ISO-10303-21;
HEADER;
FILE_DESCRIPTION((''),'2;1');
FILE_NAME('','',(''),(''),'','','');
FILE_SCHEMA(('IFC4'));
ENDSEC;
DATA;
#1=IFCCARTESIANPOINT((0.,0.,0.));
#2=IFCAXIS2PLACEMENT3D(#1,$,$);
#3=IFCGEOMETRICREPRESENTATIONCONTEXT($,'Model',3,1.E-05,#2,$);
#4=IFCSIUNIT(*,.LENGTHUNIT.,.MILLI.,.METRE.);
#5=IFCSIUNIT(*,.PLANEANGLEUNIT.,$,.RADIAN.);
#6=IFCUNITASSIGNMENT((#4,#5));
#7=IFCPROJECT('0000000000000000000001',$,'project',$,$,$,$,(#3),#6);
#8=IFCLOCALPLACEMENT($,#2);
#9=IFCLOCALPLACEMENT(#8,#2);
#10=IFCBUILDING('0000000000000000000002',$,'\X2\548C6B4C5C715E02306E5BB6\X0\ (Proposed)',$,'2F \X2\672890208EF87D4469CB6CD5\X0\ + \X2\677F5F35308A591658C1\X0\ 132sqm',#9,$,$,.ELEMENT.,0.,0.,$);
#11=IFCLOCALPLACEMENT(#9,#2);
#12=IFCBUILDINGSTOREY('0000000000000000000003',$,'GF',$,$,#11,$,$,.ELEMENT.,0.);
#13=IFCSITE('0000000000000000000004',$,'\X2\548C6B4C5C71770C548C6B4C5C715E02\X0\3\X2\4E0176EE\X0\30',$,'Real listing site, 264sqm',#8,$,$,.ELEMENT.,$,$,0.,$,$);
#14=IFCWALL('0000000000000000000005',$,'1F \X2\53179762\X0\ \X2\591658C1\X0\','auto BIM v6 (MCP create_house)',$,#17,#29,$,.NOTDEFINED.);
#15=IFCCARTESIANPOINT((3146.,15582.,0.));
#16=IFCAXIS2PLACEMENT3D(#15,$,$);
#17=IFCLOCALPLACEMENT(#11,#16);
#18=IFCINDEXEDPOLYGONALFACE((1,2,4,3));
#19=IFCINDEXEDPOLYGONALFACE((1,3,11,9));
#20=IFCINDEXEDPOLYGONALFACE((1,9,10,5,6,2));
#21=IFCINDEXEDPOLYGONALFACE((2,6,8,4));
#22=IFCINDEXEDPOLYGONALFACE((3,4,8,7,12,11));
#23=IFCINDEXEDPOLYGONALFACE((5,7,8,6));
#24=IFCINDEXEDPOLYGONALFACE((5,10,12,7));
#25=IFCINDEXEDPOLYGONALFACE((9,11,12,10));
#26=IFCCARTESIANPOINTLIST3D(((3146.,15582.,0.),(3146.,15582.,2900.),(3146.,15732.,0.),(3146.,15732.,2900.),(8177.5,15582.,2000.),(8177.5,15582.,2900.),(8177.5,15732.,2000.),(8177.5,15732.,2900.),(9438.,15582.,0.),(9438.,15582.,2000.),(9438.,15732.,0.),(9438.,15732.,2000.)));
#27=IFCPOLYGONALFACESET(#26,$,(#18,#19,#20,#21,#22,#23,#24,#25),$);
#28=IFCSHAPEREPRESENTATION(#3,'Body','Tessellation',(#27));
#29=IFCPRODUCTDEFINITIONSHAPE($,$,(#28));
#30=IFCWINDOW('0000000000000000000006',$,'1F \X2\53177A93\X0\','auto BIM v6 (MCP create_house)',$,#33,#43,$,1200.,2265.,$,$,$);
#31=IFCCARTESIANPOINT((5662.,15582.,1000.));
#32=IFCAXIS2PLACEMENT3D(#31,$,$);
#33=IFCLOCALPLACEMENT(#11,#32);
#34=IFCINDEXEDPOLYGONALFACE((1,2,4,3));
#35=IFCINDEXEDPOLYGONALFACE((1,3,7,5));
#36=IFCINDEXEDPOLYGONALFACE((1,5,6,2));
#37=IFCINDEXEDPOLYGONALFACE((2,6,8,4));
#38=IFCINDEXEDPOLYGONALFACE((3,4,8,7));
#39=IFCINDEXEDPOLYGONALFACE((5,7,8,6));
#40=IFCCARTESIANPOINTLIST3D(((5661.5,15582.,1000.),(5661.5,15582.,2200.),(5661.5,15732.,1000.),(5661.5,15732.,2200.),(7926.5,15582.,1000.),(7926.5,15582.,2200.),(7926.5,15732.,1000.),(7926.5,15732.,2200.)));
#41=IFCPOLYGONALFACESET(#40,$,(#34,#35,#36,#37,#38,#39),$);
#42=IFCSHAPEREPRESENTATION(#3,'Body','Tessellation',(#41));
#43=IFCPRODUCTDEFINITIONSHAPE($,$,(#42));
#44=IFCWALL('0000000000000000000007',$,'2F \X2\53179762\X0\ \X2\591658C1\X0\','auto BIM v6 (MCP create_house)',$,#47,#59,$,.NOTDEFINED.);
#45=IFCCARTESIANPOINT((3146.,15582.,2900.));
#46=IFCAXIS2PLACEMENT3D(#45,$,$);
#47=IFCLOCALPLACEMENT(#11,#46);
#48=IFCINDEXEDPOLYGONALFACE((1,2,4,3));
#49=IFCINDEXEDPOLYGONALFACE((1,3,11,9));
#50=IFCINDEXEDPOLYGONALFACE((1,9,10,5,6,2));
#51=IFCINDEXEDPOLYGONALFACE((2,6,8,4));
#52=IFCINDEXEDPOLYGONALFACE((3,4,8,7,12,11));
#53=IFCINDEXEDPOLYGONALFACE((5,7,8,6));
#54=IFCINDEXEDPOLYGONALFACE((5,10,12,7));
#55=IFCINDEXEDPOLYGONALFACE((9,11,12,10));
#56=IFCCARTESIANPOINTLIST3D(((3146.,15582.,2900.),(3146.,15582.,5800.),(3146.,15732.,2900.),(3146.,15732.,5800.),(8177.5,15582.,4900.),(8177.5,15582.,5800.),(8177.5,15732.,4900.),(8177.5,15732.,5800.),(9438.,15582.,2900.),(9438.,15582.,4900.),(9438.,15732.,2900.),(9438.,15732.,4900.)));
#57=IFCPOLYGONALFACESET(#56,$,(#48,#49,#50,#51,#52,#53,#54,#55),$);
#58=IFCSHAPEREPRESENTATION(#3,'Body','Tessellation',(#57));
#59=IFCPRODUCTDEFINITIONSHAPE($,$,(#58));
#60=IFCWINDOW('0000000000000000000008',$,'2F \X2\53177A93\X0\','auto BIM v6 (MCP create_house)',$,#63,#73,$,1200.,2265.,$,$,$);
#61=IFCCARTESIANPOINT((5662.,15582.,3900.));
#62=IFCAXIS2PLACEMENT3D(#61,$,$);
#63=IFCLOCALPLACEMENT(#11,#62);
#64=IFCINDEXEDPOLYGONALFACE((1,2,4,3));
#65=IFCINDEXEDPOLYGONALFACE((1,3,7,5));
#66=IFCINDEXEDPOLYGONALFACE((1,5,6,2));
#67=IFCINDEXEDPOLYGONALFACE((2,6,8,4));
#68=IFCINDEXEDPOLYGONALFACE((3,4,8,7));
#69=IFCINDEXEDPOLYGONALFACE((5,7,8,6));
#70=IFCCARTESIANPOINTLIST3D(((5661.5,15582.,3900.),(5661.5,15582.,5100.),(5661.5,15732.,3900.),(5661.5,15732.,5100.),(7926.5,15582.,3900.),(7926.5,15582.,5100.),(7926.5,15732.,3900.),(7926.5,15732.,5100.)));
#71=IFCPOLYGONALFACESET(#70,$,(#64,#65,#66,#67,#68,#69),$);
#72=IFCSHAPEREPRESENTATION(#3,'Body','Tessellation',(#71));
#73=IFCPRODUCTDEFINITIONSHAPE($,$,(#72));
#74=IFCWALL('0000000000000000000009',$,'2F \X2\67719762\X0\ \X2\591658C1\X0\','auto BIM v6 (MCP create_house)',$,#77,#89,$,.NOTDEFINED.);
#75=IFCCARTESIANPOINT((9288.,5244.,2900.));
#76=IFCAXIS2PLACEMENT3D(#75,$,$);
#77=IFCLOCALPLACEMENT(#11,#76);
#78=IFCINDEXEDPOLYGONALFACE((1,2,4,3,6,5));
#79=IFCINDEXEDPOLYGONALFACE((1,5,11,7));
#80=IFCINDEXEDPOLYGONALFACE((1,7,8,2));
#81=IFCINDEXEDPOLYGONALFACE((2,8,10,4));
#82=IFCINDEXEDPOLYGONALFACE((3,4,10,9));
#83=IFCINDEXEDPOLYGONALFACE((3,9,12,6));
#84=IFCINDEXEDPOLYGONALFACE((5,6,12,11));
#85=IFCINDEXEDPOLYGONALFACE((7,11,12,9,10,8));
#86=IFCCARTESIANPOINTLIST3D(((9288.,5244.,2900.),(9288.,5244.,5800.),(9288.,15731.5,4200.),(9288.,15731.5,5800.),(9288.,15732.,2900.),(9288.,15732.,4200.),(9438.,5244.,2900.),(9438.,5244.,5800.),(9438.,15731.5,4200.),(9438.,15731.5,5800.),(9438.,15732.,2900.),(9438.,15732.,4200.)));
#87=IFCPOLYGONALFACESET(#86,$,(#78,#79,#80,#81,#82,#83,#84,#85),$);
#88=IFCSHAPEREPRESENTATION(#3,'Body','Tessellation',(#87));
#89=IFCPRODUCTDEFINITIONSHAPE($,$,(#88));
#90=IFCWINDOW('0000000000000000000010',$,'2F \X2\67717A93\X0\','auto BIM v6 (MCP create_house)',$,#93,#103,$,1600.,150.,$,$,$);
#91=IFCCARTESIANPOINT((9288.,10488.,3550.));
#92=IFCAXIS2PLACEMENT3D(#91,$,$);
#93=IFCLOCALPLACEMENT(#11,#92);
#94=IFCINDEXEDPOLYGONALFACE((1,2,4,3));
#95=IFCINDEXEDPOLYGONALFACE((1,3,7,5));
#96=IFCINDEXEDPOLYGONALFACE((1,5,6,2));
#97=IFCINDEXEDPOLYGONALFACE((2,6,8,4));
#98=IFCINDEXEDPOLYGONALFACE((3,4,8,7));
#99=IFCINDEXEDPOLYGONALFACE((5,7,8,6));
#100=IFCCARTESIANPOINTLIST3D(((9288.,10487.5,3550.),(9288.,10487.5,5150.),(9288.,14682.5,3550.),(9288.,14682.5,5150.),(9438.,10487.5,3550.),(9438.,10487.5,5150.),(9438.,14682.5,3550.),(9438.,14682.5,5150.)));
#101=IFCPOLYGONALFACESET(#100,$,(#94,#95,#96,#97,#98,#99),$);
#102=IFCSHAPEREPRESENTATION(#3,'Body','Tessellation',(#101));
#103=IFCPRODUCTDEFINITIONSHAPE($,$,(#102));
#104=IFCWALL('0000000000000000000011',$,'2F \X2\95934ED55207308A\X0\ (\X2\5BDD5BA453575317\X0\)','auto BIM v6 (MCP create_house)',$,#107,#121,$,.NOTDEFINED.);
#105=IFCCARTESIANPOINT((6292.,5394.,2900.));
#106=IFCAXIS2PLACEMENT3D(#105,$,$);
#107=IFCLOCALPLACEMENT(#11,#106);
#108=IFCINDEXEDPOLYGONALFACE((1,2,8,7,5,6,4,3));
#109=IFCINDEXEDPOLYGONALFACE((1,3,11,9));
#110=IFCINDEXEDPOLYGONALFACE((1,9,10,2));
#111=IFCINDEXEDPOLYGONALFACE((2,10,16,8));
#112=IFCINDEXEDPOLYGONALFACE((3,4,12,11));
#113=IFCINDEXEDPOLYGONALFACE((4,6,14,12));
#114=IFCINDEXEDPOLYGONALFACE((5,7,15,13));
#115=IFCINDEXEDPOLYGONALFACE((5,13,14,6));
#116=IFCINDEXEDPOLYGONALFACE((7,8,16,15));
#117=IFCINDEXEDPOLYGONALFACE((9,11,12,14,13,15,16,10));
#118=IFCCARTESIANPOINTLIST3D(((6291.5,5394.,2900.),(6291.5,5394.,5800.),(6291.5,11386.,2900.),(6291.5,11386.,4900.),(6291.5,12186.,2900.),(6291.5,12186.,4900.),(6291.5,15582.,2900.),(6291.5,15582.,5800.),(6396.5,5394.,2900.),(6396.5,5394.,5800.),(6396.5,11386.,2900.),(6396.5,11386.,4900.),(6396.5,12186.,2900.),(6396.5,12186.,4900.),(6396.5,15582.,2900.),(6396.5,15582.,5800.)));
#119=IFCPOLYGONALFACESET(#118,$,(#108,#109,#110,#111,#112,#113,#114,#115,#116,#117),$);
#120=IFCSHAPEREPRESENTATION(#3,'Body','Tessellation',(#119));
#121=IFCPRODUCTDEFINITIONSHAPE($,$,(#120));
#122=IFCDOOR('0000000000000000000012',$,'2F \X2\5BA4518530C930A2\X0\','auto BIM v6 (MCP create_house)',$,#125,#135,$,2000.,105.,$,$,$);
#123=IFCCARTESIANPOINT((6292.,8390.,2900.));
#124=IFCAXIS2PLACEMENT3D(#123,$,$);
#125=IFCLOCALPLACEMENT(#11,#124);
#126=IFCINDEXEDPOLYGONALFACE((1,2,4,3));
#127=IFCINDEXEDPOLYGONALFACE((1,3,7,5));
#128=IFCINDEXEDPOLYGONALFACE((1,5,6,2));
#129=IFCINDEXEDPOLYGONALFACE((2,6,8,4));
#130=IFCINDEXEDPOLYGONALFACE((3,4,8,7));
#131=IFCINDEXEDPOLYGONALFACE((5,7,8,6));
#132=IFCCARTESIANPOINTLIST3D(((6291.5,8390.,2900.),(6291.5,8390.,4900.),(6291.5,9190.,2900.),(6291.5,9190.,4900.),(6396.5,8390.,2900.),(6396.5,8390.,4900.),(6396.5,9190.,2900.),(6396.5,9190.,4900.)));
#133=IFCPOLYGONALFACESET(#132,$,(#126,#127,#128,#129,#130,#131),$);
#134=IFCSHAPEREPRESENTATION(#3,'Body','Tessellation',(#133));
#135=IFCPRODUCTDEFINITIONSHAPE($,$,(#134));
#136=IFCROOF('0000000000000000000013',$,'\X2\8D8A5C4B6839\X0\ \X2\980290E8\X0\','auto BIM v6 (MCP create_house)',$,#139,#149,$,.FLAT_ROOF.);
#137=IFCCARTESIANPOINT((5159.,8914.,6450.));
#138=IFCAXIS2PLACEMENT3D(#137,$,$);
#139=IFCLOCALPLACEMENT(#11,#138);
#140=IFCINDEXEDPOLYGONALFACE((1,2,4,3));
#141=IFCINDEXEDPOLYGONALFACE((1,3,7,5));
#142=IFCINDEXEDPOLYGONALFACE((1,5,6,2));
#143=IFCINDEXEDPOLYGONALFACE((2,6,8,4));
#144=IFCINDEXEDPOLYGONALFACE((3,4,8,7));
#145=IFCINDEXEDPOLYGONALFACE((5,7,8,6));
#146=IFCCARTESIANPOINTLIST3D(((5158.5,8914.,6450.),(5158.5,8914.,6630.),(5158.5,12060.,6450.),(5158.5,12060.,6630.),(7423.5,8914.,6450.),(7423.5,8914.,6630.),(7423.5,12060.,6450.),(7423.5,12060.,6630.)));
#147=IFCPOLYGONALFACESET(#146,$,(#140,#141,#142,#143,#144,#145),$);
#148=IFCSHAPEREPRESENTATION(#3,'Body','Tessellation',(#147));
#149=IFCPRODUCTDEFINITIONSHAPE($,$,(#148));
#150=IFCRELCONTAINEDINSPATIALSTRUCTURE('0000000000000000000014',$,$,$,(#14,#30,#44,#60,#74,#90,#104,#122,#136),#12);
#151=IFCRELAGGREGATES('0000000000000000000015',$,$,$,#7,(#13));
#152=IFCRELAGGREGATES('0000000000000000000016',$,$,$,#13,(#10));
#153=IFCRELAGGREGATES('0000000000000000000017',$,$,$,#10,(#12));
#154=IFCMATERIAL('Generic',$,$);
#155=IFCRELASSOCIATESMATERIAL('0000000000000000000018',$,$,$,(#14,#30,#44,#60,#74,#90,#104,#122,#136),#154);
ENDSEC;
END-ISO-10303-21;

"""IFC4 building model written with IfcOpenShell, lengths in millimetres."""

from ifc_helpers import new_model, si_unit, frame, frame_2d, origin, place, context, project, spatial, rectangle, extrude, material, element, fill, save


model = new_model("IFC4")

# Units and contexts
model_context = context("Model", 3, precision=1e-05, world=origin())
ifc_project = project(units=[si_unit("LENGTHUNIT", "METRE", prefix="MILLI"), si_unit("PLANEANGLEUNIT", "RADIAN")], contexts=[model_context])

# Site, building, storey
site_placement = place(None, origin())
site = spatial("IfcSite", under=ifc_project, at=site_placement, Name="和歌山県和歌山市3丁目30", ObjectType="Real listing site, 264sqm", CompositionType="ELEMENT", RefElevation=0.0)
building_placement = place(site_placement, origin())
building = spatial("IfcBuilding", under=site, at=building_placement, Name="和歌山市の家 (Proposed)", ObjectType="2F 木造軸組構法 + 板張り外壁 132sqm", CompositionType="ELEMENT", ElevationOfRefHeight=0.0, ElevationOfTerrain=0.0)
storey_placement = place(building_placement, origin())
storey = spatial("IfcBuildingStorey", under=building, at=storey_placement, Name="GF", CompositionType="ELEMENT", Elevation=0.0)

# Wall, opening, window
ifc_material = material(Name="Generic")
wall_1_placement = place(storey_placement, frame((3146.0, 15582.0, 0.0)))
wall_1 = element("IfcWall", 1, at=wall_1_placement, inside=storey, material=ifc_material, Name="1F 北面 外壁", Description="auto BIM v6 (MCP create_house)", PredefinedType="NOTDEFINED", context=model_context, shape_type="SweptSolid", body=[
    extrude(rectangle(XDim=6292.0, YDim=150.0, at=frame_2d((3146.0, 75.0))), frame((3146.0, 15582.0, 0.0)), (0.0, 0.0, 1.0), 2900.0),
])
opening_1_placement = place(storey_placement, frame((5662.0, 15582.0, 1000.0)))
opening_1 = element("IfcOpeningElement", 2, at=opening_1_placement, cuts=wall_1, PredefinedType="NOTDEFINED", context=model_context, shape_type="SweptSolid", body=[
    extrude(rectangle(XDim=2265.0, YDim=150.0, at=frame_2d((1132.0, 75.0))), frame((5662.0, 15582.0, 1000.0)), (0.0, 0.0, 1.0), 1200.0),
])
window_1_placement = place(storey_placement, frame((5662.0, 15582.0, 1000.0)))
window_1 = element("IfcWindow", 3, at=window_1_placement, inside=storey, material=ifc_material, Name="1F 北窓", Description="auto BIM v6 (MCP create_house)", OverallHeight=1200.0, OverallWidth=2265.0, context=model_context, shape_type="SweptSolid", body=[
    extrude(rectangle(XDim=2265.0, YDim=150.0, at=frame_2d((1132.0, 75.0))), frame((5662.0, 15582.0, 1000.0)), (0.0, 0.0, 1.0), 1200.0),
])
fill(opening_1, window_1)

# Walls, openings, windows
wall_2_placement = place(storey_placement, frame((3146.0, 15582.0, 2900.0)))
wall_2 = element("IfcWall", 4, at=wall_2_placement, inside=storey, material=ifc_material, Name="2F 北面 外壁", Description="auto BIM v6 (MCP create_house)", PredefinedType="NOTDEFINED", context=model_context, shape_type="SweptSolid", body=[
    extrude(rectangle(XDim=6292.0, YDim=150.0, at=frame_2d((3146.0, 75.0))), frame((3146.0, 15582.0, 2900.0)), (0.0, 0.0, 1.0), 2900.0),
])
opening_2_placement = place(storey_placement, frame((5662.0, 15582.0, 3900.0)))
opening_2 = element("IfcOpeningElement", 5, at=opening_2_placement, cuts=wall_2, PredefinedType="NOTDEFINED", context=model_context, shape_type="SweptSolid", body=[
    extrude(rectangle(XDim=2265.0, YDim=150.0, at=frame_2d((1132.0, 75.0))), frame((5662.0, 15582.0, 3900.0)), (0.0, 0.0, 1.0), 1200.0),
])
window_2_placement = place(storey_placement, frame((5662.0, 15582.0, 3900.0)))
window_2 = element("IfcWindow", 6, at=window_2_placement, inside=storey, material=ifc_material, Name="2F 北窓", Description="auto BIM v6 (MCP create_house)", OverallHeight=1200.0, OverallWidth=2265.0, context=model_context, shape_type="SweptSolid", body=[
    extrude(rectangle(XDim=2265.0, YDim=150.0, at=frame_2d((1132.0, 75.0))), frame((5662.0, 15582.0, 3900.0)), (0.0, 0.0, 1.0), 1200.0),
])
fill(opening_2, window_2)
wall_3_placement = place(storey_placement, frame((9288.0, 5244.0, 2900.0)))
wall_3 = element("IfcWall", 7, at=wall_3_placement, inside=storey, material=ifc_material, Name="2F 東面 外壁", Description="auto BIM v6 (MCP create_house)", PredefinedType="NOTDEFINED", context=model_context, shape_type="SweptSolid", body=[
    extrude(rectangle(XDim=150.0, YDim=10488.0, at=frame_2d((75.0, 5244.0))), frame((9288.0, 5244.0, 2900.0)), (0.0, 0.0, 1.0), 2900.0),
])
opening_3_placement = place(storey_placement, frame((9288.0, 10488.0, 3550.0)))
opening_3 = element("IfcOpeningElement", 8, at=opening_3_placement, cuts=wall_3, PredefinedType="NOTDEFINED", context=model_context, shape_type="SweptSolid", body=[
    extrude(rectangle(XDim=150.0, YDim=4195.0, at=frame_2d((75.0, 2097.0))), frame((9288.0, 10488.0, 3550.0)), (0.0, 0.0, 1.0), 1600.0),
])
window_3_placement = place(storey_placement, frame((9288.0, 10488.0, 3550.0)))
window_3 = element("IfcWindow", 9, at=window_3_placement, inside=storey, material=ifc_material, Name="2F 東窓", Description="auto BIM v6 (MCP create_house)", OverallHeight=1600.0, OverallWidth=150.0, context=model_context, shape_type="SweptSolid", body=[
    extrude(rectangle(XDim=150.0, YDim=4195.0, at=frame_2d((75.0, 2097.0))), frame((9288.0, 10488.0, 3550.0)), (0.0, 0.0, 1.0), 1600.0),
])
fill(opening_3, window_3)

# Wall, opening, door
wall_4_placement = place(storey_placement, frame((6292.0, 5394.0, 2900.0)))
wall_4 = element("IfcWall", 10, at=wall_4_placement, inside=storey, material=ifc_material, Name="2F 間仕切り (寝室南北)", Description="auto BIM v6 (MCP create_house)", PredefinedType="NOTDEFINED", context=model_context, shape_type="SweptSolid", body=[
    extrude(rectangle(XDim=105.0, YDim=10188.0, at=frame_2d((52.0, 5094.0))), frame((6292.0, 5394.0, 2900.0)), (0.0, 0.0, 1.0), 2900.0),
])
opening_4_placement = place(storey_placement, frame((6292.0, 8390.0, 2900.0)))
opening_4 = element("IfcOpeningElement", 11, at=opening_4_placement, cuts=wall_4, PredefinedType="NOTDEFINED", context=model_context, shape_type="SweptSolid", body=[
    extrude(rectangle(XDim=105.0, YDim=800.0, at=frame_2d((52.0, 400.0))), frame((6292.0, 8390.0, 2900.0)), (0.0, 0.0, 1.0), 2000.0),
])
door_placement = place(storey_placement, frame((6292.0, 8390.0, 2900.0)))
door = element("IfcDoor", 12, at=door_placement, inside=storey, material=ifc_material, Name="2F 室内ドア", Description="auto BIM v6 (MCP create_house)", OverallHeight=2000.0, OverallWidth=105.0, context=model_context, shape_type="SweptSolid", body=[
    extrude(rectangle(XDim=105.0, YDim=800.0, at=frame_2d((52.0, 400.0))), frame((6292.0, 8390.0, 2900.0)), (0.0, 0.0, 1.0), 2000.0),
])
fill(opening_4, door)

# Roof
roof_placement = place(storey_placement, frame((5159.0, 8914.0, 6450.0)))
element("IfcRoof", 13, at=roof_placement, inside=storey, material=ifc_material, Name="越屋根 頂部", Description="auto BIM v6 (MCP create_house)", PredefinedType="FLAT_ROOF", context=model_context, shape_type="SweptSolid", body=[
    extrude(rectangle(XDim=2265.0, YDim=3146.0, at=frame_2d((1132.0, 1573.0))), frame((5159.0, 8914.0, 6450.0)), (0.0, 0.0, 1.0), 180.0),
])

save(model, "model.ifc")
